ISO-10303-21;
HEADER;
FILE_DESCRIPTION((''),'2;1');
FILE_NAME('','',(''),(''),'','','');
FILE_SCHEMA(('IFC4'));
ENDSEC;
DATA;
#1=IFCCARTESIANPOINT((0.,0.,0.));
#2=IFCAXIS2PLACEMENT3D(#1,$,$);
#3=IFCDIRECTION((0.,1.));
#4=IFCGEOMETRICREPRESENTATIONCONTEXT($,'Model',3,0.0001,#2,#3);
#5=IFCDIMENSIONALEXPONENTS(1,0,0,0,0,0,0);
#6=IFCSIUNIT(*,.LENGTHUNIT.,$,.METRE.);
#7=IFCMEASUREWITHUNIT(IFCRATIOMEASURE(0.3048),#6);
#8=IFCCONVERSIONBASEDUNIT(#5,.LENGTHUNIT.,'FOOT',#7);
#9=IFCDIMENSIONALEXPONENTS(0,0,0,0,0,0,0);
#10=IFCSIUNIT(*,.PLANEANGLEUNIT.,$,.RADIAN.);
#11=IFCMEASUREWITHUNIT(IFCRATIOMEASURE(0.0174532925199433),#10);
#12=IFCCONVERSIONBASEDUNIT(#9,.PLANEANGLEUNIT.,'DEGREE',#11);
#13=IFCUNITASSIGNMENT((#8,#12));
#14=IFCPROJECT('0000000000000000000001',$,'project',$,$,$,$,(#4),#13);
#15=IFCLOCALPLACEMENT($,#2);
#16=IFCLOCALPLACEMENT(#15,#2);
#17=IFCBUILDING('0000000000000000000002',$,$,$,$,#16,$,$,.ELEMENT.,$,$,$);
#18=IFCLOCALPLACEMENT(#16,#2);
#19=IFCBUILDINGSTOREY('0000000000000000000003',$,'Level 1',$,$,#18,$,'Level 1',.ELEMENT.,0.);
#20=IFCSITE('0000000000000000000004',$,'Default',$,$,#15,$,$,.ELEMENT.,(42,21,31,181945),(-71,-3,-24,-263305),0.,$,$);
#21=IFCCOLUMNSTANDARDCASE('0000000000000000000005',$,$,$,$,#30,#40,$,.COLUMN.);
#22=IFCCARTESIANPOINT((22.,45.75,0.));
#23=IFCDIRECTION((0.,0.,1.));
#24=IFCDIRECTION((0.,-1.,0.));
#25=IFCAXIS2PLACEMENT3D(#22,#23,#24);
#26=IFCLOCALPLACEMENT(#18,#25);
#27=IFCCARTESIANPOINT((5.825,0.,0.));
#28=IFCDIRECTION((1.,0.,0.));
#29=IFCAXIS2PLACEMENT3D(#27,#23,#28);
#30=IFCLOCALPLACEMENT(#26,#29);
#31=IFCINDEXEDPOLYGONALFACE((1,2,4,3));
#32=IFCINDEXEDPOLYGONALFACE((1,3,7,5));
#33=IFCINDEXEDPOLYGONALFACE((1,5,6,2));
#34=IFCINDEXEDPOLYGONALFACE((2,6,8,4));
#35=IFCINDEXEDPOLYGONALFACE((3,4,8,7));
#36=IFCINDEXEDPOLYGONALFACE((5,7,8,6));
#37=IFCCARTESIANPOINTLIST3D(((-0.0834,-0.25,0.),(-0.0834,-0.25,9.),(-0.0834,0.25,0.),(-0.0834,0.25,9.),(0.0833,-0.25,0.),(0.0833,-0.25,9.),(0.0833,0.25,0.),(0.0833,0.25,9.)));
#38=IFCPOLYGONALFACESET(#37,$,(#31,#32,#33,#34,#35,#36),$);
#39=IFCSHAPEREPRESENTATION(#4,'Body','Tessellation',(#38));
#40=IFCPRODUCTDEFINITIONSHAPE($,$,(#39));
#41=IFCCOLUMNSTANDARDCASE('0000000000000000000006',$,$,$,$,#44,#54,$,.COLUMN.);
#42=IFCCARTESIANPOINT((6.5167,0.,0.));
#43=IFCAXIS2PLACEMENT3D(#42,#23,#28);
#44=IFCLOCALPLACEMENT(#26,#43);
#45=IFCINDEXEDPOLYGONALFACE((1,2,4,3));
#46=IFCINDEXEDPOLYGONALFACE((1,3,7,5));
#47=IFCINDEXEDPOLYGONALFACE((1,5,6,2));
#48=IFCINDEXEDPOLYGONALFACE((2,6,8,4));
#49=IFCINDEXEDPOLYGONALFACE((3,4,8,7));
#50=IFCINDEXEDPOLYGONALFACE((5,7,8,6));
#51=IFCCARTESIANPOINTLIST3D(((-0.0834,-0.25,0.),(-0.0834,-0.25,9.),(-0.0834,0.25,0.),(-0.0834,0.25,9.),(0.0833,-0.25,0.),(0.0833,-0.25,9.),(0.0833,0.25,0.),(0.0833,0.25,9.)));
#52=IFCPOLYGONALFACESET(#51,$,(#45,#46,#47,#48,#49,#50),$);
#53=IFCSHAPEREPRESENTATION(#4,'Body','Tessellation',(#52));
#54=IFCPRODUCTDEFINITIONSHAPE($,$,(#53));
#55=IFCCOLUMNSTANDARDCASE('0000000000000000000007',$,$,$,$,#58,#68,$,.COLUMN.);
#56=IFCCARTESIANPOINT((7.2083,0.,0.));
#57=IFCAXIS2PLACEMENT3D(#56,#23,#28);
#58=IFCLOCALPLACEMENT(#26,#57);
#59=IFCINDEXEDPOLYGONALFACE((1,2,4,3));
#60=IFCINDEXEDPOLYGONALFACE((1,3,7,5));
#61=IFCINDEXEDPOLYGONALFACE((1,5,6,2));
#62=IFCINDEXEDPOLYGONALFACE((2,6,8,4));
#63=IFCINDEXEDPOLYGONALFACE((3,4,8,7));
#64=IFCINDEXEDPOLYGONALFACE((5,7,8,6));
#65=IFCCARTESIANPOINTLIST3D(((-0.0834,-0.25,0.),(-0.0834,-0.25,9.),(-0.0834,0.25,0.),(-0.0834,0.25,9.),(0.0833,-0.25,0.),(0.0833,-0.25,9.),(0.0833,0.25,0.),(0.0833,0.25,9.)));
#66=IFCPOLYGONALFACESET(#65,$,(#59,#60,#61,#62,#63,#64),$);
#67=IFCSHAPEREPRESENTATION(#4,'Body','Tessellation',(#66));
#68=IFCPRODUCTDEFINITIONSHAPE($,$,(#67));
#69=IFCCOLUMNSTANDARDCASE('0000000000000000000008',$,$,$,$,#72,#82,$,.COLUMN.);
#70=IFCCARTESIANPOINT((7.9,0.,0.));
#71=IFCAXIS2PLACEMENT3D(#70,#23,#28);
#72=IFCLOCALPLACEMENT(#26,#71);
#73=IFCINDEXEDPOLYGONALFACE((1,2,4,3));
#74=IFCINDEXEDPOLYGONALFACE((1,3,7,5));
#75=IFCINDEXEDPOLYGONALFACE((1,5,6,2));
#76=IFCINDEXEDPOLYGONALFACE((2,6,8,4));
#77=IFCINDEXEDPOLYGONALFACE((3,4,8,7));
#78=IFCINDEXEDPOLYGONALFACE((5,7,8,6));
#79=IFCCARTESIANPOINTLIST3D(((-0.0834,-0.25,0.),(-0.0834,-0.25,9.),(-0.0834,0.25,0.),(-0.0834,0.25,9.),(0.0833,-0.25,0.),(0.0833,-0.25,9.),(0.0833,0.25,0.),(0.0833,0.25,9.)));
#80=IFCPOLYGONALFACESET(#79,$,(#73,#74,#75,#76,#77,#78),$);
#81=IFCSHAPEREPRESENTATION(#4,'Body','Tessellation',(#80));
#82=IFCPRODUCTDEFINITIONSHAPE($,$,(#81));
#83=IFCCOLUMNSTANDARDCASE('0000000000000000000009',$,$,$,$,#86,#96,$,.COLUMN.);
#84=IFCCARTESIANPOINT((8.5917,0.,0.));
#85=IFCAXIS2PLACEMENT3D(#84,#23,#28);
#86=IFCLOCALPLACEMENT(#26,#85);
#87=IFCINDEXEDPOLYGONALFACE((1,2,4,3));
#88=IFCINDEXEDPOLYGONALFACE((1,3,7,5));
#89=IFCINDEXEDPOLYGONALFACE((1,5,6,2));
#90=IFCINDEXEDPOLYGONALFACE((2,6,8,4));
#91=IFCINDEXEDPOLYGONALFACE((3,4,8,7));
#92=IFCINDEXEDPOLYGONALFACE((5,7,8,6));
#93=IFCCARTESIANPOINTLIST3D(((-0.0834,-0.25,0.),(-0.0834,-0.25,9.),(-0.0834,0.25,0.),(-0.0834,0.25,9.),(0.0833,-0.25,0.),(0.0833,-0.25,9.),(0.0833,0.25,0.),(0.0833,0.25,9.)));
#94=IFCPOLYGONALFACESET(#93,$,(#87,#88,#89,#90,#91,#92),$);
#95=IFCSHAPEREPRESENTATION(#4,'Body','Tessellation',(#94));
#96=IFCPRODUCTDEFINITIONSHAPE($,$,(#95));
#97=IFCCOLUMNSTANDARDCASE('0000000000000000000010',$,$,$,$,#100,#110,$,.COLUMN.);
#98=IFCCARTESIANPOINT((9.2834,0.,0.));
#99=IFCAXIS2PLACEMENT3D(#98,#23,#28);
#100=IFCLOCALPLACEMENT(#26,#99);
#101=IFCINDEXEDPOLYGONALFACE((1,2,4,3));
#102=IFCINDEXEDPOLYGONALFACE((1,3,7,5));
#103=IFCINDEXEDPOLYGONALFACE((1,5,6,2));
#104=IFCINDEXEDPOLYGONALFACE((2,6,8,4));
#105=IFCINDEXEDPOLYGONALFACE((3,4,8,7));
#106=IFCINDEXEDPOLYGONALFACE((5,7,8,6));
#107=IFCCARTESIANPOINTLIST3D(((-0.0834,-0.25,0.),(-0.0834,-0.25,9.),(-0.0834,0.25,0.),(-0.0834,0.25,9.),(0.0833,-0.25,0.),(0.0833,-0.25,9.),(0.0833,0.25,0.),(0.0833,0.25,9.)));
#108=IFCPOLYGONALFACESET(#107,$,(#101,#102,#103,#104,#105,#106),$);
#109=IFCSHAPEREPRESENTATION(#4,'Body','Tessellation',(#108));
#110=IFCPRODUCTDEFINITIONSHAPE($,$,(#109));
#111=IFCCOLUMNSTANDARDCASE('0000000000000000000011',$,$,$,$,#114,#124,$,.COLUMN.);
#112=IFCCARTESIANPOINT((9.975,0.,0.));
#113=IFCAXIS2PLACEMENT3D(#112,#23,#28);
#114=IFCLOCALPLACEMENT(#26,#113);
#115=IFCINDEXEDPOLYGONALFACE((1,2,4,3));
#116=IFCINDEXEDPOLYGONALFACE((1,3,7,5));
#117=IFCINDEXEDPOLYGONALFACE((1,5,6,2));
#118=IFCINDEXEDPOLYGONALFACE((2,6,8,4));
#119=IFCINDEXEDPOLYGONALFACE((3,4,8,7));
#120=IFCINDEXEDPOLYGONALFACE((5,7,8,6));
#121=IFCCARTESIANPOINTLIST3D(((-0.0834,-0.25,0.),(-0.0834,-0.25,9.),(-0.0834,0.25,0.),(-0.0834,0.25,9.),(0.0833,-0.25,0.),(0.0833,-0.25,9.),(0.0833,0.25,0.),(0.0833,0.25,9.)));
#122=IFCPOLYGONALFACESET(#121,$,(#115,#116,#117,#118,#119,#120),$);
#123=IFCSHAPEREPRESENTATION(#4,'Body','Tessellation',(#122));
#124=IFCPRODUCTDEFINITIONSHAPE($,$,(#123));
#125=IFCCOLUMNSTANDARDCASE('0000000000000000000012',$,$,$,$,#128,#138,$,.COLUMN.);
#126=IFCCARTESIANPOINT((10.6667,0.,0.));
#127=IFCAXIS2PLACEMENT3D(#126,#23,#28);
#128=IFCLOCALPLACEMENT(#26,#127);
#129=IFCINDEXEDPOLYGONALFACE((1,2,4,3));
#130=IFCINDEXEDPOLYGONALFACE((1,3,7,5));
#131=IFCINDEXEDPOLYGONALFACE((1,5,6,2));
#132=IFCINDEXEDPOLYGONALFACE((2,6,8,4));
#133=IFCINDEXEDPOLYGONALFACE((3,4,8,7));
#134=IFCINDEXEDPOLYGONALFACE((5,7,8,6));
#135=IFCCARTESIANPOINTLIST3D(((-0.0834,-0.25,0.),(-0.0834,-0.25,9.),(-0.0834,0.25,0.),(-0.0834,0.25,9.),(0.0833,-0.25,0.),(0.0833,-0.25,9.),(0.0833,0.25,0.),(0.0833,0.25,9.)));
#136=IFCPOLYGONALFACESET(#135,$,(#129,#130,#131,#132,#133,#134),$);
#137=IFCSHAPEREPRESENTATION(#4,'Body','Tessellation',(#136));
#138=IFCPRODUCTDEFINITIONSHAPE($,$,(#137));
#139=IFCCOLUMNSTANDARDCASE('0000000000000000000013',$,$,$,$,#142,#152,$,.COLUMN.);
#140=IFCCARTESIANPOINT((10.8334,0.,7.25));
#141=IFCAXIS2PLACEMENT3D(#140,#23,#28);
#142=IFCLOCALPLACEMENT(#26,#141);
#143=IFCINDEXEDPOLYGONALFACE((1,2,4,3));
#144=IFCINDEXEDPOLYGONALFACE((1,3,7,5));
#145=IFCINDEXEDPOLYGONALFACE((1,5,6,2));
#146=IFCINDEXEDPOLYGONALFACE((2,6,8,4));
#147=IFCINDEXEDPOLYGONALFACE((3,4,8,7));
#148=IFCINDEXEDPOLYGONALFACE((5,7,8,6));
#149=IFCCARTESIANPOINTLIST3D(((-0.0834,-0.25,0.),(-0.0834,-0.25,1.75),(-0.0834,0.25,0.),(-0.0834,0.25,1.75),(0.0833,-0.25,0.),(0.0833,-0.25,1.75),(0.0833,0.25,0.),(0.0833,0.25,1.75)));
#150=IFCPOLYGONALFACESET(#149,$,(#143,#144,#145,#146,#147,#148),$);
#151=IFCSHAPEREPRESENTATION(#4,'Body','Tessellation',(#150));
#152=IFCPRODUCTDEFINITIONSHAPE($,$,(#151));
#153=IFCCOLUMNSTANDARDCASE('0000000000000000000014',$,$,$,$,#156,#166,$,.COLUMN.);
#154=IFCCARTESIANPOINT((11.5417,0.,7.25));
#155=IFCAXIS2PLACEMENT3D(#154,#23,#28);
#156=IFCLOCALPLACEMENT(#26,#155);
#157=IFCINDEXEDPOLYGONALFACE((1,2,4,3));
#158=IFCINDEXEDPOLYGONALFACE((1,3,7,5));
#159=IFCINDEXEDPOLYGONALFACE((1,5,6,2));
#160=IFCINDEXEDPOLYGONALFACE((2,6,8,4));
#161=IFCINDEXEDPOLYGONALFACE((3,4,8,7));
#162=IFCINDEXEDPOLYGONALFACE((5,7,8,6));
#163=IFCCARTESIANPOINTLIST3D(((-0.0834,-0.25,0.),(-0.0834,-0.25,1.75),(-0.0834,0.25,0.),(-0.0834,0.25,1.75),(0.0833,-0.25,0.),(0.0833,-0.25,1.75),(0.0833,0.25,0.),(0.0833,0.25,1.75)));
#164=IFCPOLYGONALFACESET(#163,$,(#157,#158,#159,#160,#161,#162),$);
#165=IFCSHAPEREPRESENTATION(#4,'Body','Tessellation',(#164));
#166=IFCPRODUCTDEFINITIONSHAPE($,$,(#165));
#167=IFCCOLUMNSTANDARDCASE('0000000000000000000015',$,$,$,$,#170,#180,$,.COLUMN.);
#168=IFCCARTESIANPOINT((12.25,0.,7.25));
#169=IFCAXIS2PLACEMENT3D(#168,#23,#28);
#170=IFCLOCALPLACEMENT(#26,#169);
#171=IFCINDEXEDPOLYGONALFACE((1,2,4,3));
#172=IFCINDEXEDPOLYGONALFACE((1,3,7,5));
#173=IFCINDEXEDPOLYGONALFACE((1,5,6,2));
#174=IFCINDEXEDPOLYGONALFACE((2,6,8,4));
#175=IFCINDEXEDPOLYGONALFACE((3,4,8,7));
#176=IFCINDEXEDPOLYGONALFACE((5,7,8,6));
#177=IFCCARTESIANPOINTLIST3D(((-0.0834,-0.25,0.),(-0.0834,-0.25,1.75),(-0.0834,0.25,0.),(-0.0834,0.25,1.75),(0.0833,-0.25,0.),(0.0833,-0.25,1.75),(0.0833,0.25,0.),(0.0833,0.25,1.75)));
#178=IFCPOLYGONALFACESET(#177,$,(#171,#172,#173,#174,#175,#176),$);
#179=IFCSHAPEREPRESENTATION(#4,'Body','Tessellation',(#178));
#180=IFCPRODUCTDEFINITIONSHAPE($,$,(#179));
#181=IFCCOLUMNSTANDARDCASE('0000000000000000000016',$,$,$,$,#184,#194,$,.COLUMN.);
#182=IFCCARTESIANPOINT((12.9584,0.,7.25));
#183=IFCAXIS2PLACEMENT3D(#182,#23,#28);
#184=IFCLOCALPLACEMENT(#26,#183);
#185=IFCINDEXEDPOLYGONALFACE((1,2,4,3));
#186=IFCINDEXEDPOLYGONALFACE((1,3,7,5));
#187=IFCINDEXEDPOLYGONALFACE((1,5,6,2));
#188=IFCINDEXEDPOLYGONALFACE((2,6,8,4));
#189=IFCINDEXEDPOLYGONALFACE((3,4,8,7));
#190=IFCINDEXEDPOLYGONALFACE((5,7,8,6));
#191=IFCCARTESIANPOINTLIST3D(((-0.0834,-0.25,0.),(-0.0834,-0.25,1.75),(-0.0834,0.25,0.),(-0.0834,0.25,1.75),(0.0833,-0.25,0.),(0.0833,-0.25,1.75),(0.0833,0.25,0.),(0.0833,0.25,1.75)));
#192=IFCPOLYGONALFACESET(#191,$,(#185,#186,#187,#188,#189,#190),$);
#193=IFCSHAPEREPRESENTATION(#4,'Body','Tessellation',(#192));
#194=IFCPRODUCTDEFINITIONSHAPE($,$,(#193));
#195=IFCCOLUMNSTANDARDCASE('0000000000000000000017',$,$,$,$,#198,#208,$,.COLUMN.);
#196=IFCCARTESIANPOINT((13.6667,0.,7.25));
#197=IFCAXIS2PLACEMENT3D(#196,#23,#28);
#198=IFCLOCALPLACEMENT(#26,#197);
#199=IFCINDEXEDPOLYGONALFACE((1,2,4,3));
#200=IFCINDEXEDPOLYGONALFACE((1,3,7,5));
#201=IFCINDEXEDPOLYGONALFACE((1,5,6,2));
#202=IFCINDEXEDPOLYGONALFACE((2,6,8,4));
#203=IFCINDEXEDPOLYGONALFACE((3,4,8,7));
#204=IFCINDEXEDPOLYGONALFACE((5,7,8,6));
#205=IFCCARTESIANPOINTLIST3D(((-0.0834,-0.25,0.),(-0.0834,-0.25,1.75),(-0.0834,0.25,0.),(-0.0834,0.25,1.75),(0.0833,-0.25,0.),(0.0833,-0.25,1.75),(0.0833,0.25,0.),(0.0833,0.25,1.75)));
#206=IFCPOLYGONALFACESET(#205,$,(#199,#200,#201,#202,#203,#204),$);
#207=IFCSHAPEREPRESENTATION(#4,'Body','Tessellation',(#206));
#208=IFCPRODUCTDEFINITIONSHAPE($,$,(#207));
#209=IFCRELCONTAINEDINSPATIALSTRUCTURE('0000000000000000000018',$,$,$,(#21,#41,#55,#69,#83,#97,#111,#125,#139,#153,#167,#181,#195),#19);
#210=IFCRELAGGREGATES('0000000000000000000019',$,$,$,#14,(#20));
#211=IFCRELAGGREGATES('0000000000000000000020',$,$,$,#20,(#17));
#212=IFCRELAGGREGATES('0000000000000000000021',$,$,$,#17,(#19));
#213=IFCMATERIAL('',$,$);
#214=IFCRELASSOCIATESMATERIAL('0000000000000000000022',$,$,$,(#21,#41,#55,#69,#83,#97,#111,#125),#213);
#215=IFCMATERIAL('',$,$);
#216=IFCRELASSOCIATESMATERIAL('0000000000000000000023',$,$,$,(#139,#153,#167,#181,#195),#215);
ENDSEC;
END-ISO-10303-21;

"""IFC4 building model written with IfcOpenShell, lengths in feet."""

from ifc_helpers import new_model, entity, si_unit, converted_unit, direction, frame, origin, place, context, project, spatial, rectangle, extrude, material, element, save


model = new_model("IFC4")

# Units and contexts
model_context = context("Model", 3, precision=0.0001, world=origin(), true_north=direction((0.0, 1.0)))
ifc_project = project(units=[converted_unit("LENGTHUNIT", "FOOT", entity("IfcRatioMeasure", 0.3048), si_unit("LENGTHUNIT", "METRE"), dimensions=[1, 0, 0, 0, 0, 0, 0]), converted_unit("PLANEANGLEUNIT", "DEGREE", entity("IfcRatioMeasure", 0.0174532925199433), si_unit("PLANEANGLEUNIT", "RADIAN"), dimensions=[0, 0, 0, 0, 0, 0, 0])], contexts=[model_context])

# Site, building, storey
site_placement = place(None, origin())
site = spatial("IfcSite", under=ifc_project, at=site_placement, Name="Default", CompositionType="ELEMENT", RefLatitude=(42, 21, 31, 181945), RefLongitude=(-71, -3, -24, -263305), RefElevation=0.0)
building_placement = place(site_placement, origin())
building = spatial("IfcBuilding", under=site, at=building_placement, CompositionType="ELEMENT")
storey_placement = place(building_placement, origin())
storey = spatial("IfcBuildingStorey", under=building, at=storey_placement, Name="Level 1", LongName="Level 1", CompositionType="ELEMENT", Elevation=0.0)

# Columns
placement_1 = place(storey_placement, frame((22.0, 45.75, 0.0), z_axis=(0.0, 0.0, 1.0), x_axis=(0.0, -1.0, 0.0)))
ifc_material_1 = material(Name="")
for number, where, z_axis, x_axis in (
    (1, (5.825, 0.0, 0.0), (0.0, 0.0, 1.0), (1.0, 0.0, 0.0)),
    (2, (6.5167, 0.0, 0.0), (0.0, 0.0, 1.0), (1.0, 0.0, 0.0)),
    (3, (7.2083, 0.0, 0.0), (0.0, 0.0, 1.0), (1.0, 0.0, 0.0)),
    (4, (7.9, 0.0, 0.0), (0.0, 0.0, 1.0), (1.0, 0.0, 0.0)),
    (5, (8.5917, 0.0, 0.0), (0.0, 0.0, 1.0), (1.0, 0.0, 0.0)),
    (6, (9.2834, 0.0, 0.0), (0.0, 0.0, 1.0), (1.0, 0.0, 0.0)),
    (7, (9.975, 0.0, 0.0), (0.0, 0.0, 1.0), (1.0, 0.0, 0.0)),
    (8, (10.6667, 0.0, 0.0), (0.0, 0.0, 1.0), (1.0, 0.0, 0.0)),
):
    element("IfcColumnStandardCase", number, at=place(placement_1, frame(where, z_axis=z_axis, x_axis=x_axis)), inside=storey, material=ifc_material_1, PredefinedType="COLUMN", context=model_context, shape_type="SweptSolid", body=[
        extrude(rectangle(XDim=0.1667, YDim=0.5), origin(), (0.0, 0.0, 1.0), 9.0),
    ])
ifc_material_2 = material(Name="")
for number, where, z_axis, x_axis in (
    (9, (10.8334, 0.0, 7.25), (0.0, 0.0, 1.0), (1.0, 0.0, 0.0)),
    (10, (11.5417, 0.0, 7.25), (0.0, 0.0, 1.0), (1.0, 0.0, 0.0)),
    (11, (12.25, 0.0, 7.25), (0.0, 0.0, 1.0), (1.0, 0.0, 0.0)),
    (12, (12.9584, 0.0, 7.25), (0.0, 0.0, 1.0), (1.0, 0.0, 0.0)),
    (13, (13.6667, 0.0, 7.25), (0.0, 0.0, 1.0), (1.0, 0.0, 0.0)),
):
    element("IfcColumnStandardCase", number, at=place(placement_1, frame(where, z_axis=z_axis, x_axis=x_axis)), inside=storey, material=ifc_material_2, PredefinedType="COLUMN", context=model_context, shape_type="SweptSolid", body=[
        extrude(rectangle(XDim=0.1667, YDim=0.5), origin(), (0.0, 0.0, 1.0), 1.75),
    ])

save(model, "model.ifc")
